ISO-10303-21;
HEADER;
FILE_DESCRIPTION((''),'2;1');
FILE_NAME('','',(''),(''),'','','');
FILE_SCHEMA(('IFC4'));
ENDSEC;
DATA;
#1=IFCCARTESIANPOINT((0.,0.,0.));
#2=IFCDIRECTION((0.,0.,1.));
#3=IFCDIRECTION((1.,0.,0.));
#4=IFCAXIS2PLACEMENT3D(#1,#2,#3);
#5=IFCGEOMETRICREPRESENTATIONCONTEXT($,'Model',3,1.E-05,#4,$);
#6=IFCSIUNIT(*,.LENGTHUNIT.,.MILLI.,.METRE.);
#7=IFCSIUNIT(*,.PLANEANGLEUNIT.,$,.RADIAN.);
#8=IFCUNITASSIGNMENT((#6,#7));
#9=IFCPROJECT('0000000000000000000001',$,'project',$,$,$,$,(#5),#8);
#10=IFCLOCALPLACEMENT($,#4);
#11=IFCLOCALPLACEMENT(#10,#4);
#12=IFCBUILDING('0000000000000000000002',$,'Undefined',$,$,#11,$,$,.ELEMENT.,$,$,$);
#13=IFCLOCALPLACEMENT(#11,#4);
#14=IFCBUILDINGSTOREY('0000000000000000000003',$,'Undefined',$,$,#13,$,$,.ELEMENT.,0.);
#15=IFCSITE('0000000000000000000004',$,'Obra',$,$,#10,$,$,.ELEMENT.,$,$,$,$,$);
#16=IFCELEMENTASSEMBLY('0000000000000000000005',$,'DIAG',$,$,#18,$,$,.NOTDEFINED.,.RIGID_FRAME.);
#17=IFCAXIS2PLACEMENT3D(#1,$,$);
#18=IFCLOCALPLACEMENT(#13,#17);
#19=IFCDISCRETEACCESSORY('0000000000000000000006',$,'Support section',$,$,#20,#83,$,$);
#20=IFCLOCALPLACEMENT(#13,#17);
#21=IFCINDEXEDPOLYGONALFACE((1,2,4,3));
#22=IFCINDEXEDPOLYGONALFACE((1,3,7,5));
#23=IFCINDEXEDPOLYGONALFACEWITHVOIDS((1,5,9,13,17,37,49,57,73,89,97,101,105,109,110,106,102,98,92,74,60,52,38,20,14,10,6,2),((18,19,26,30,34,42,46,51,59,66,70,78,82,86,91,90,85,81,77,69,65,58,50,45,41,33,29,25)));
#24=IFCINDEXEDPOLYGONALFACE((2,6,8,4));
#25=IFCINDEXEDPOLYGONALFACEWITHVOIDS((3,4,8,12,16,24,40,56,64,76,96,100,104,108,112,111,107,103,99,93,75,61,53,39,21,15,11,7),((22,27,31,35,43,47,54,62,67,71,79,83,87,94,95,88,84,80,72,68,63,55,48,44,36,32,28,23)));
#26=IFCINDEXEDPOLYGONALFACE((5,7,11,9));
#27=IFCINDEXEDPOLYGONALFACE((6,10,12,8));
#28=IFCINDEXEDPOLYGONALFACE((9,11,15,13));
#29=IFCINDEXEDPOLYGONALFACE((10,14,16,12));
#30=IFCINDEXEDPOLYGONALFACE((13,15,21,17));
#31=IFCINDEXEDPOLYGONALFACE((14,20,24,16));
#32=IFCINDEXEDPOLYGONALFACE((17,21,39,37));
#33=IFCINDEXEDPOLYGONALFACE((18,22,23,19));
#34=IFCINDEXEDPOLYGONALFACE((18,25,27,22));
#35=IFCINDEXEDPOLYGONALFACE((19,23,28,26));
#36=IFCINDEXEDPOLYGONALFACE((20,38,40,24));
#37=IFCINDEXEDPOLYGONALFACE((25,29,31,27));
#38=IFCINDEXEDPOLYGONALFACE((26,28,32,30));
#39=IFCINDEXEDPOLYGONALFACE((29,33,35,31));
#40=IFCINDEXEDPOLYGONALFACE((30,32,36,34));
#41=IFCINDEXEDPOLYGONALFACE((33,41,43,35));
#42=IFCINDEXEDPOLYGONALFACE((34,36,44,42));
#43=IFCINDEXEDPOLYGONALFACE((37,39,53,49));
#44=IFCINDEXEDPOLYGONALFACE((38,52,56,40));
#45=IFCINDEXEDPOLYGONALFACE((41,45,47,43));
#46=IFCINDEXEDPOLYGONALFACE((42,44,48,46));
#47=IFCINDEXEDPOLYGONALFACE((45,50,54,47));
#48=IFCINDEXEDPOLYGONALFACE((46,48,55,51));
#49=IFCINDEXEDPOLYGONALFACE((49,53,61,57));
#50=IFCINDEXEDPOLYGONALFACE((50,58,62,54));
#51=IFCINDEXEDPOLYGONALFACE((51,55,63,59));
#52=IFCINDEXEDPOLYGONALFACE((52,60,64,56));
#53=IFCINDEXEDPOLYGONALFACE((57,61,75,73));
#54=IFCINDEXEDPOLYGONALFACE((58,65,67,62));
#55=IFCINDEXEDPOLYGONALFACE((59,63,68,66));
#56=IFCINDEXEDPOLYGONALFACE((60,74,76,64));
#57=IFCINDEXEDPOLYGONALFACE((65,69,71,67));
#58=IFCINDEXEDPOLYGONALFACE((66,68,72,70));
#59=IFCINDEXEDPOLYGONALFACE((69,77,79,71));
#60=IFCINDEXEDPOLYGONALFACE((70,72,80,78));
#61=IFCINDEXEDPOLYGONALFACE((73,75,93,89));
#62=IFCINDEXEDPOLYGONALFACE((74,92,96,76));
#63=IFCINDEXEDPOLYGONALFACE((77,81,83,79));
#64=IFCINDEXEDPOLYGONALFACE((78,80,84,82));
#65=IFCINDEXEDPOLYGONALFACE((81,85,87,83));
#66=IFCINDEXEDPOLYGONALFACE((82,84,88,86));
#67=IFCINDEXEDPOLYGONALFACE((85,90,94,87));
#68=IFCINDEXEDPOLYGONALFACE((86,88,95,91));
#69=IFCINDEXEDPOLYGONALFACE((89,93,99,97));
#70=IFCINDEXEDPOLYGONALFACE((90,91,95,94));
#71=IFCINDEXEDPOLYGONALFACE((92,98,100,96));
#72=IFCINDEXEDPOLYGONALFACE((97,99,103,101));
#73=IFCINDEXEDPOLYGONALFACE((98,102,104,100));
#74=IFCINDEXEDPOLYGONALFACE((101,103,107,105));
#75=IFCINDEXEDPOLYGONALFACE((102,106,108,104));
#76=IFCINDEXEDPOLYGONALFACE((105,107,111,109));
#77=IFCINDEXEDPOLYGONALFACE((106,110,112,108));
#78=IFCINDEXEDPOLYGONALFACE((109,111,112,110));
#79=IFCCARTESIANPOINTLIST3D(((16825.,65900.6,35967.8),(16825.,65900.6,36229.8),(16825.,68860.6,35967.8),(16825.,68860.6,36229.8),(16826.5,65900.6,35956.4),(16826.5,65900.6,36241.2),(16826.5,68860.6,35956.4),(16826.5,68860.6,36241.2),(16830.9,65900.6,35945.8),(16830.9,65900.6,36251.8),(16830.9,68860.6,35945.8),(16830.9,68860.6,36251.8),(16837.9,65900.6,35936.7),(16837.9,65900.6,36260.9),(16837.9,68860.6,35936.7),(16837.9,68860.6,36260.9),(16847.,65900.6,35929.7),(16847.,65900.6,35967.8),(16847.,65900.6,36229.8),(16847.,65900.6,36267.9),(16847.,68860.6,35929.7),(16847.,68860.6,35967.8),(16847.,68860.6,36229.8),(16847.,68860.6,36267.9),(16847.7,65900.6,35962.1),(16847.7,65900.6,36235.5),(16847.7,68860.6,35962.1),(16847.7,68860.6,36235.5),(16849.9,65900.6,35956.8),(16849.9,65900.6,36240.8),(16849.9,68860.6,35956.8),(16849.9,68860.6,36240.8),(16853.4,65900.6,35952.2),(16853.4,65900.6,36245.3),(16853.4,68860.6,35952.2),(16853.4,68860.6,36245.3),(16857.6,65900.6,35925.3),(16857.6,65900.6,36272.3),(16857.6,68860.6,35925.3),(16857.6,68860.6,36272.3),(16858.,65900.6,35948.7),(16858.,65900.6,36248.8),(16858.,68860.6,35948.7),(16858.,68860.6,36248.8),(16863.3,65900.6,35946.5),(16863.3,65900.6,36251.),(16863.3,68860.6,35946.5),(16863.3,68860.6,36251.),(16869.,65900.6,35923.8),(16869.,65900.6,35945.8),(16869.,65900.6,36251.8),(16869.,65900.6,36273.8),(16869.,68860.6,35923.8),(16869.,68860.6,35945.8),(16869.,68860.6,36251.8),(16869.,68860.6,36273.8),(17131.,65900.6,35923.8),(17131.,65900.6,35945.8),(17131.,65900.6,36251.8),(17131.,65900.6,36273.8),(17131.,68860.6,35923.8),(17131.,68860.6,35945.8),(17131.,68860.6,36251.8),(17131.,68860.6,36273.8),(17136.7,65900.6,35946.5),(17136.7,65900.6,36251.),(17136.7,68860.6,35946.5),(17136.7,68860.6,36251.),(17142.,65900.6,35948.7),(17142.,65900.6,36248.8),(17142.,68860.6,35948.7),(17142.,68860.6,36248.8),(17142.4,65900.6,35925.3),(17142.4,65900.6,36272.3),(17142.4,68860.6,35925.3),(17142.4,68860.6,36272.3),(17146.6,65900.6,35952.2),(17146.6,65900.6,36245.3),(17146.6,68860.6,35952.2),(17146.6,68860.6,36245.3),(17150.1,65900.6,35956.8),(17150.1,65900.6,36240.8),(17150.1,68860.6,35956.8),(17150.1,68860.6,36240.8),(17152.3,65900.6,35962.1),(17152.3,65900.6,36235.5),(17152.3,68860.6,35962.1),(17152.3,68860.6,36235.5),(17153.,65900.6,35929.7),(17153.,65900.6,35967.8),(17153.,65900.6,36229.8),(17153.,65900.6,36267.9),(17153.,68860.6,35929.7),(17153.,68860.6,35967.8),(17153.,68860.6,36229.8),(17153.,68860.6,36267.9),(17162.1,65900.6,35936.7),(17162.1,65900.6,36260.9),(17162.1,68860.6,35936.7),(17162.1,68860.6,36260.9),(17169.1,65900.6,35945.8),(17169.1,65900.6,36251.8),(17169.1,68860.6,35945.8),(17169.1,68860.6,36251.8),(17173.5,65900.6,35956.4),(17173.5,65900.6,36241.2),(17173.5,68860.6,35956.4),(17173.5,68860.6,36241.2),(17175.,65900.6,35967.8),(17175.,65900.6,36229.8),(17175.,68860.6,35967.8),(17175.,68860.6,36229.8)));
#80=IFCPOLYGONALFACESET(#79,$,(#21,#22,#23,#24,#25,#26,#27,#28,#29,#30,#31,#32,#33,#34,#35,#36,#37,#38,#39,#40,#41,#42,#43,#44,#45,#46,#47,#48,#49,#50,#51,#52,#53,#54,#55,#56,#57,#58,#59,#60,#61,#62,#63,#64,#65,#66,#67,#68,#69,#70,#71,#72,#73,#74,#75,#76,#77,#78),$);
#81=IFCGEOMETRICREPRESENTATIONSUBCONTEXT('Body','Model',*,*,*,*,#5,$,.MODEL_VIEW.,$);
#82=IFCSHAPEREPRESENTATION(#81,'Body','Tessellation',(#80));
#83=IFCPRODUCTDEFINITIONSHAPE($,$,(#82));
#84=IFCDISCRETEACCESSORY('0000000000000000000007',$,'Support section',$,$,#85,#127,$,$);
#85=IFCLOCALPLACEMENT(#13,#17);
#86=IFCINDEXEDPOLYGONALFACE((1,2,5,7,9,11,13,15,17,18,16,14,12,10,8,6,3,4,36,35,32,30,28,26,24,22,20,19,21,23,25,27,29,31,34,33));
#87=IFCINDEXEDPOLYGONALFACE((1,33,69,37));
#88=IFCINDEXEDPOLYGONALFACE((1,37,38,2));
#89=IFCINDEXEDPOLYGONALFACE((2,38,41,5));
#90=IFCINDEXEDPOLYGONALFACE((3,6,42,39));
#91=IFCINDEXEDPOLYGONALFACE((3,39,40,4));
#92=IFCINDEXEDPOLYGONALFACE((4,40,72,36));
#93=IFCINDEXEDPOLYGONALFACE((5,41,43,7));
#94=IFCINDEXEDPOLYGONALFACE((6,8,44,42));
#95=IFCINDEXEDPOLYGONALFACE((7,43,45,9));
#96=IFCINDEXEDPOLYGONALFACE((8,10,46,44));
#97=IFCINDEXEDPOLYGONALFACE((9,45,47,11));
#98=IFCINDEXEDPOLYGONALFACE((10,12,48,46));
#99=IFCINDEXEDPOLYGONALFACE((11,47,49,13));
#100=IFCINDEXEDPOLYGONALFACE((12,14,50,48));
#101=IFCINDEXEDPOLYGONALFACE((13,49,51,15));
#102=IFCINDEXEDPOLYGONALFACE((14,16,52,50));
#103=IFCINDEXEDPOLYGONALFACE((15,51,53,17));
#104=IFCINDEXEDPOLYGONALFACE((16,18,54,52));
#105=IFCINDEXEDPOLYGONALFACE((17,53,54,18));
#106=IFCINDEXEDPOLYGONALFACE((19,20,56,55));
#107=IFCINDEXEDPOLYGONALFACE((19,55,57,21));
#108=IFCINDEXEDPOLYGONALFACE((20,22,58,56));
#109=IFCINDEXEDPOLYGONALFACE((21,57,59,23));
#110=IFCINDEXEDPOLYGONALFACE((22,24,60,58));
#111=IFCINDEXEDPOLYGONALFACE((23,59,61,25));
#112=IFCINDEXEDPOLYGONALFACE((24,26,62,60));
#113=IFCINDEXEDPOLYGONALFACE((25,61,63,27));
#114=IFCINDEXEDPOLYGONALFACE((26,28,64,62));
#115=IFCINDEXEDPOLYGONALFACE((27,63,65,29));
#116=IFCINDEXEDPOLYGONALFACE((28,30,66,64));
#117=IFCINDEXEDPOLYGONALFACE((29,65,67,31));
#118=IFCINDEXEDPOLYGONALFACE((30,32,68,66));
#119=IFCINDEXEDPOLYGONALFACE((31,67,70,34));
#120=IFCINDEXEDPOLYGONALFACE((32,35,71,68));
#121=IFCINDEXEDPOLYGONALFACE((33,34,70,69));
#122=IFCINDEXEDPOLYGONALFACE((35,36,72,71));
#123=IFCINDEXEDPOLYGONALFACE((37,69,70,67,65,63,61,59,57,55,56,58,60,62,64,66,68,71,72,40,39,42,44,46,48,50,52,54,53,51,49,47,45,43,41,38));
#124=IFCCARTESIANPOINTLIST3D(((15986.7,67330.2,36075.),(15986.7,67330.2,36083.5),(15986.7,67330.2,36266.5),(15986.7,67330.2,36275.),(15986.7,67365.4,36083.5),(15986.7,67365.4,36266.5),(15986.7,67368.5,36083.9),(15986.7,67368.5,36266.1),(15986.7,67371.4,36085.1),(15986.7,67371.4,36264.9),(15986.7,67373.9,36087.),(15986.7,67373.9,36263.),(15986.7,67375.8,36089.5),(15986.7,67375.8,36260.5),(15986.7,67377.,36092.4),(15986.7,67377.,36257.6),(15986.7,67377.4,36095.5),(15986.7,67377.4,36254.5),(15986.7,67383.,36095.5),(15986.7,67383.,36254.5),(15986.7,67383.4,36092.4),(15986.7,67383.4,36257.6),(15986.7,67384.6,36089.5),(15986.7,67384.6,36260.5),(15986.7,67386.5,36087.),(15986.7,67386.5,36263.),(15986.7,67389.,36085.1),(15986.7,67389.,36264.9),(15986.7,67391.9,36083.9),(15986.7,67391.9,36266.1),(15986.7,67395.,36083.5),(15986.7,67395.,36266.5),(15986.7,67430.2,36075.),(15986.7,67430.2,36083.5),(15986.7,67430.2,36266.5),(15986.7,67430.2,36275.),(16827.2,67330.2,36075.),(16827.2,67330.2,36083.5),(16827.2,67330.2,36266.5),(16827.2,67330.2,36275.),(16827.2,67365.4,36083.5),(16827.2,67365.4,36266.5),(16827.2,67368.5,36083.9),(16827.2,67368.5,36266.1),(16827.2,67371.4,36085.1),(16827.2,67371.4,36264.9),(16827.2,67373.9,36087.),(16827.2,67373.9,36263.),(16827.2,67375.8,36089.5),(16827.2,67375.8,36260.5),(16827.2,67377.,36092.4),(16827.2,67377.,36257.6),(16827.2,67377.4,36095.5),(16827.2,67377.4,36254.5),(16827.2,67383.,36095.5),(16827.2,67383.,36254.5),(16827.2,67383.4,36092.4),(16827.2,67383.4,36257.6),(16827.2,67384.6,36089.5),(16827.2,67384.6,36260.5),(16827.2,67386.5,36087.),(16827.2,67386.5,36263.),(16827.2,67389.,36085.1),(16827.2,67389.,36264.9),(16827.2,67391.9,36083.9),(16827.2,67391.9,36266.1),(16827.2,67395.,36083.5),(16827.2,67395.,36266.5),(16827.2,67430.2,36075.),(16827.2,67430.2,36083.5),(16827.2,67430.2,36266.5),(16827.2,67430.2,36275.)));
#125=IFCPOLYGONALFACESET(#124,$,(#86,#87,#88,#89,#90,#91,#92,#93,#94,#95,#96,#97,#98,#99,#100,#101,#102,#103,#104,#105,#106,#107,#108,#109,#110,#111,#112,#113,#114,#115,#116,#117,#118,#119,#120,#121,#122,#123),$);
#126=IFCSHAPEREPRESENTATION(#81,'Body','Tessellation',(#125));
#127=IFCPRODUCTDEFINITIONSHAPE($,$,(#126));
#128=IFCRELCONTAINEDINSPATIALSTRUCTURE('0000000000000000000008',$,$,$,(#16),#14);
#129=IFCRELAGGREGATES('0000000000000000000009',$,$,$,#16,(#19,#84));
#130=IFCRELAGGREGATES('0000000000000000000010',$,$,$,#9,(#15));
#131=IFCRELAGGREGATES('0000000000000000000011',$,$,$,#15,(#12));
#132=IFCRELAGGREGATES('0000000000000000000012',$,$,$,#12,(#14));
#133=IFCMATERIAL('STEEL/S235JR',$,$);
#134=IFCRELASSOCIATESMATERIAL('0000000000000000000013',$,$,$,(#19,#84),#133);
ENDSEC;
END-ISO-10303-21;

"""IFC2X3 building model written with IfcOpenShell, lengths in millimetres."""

from ifc_helpers import new_model, si_unit, frame, origin_with_axes, origin_2d_with_axis, place, context, subcontext, project, spatial, hollow_rectangle, i_section, extrude, clip, halfspace, material, element, aggregate, save


model = new_model("IFC2X3")

# Units and contexts
model_context = context("Model", 3, precision=1e-05, world=origin_with_axes())
body_context = subcontext(model_context, "Body", "Model", "MODEL_VIEW")
ifc_project = project(units=[si_unit("LENGTHUNIT", "METRE", prefix="MILLI"), si_unit("PLANEANGLEUNIT", "RADIAN")], contexts=[model_context])

# Site, building, storey
site_placement = place(None, origin_with_axes())
site = spatial("IfcSite", under=ifc_project, at=site_placement, Name="Obra", CompositionType="ELEMENT")
building_placement = place(site_placement, origin_with_axes())
building = spatial("IfcBuilding", under=site, at=building_placement, Name="Undefined", CompositionType="ELEMENT")
storey_placement = place(building_placement, origin_with_axes())
storey = spatial("IfcBuildingStorey", under=building, at=storey_placement, Name="Undefined", CompositionType="ELEMENT", Elevation=0.0)

# Element assembly
ifc_material_1 = material(Name="STEEL/S235JR")
assembly_1_placement = place(storey_placement, origin_with_axes())
assembly_1 = element("IfcElementAssembly", 1, at=assembly_1_placement, inside=storey, Name="DIAG", AssemblyPlace="NOTDEFINED", PredefinedType="RIGID_FRAME")

# Discrete accessories
discrete_accessory_1_placement = place(assembly_1_placement, frame((17000.0, 65880.6, 36098.8), z_axis=(0.0, 0.0, 1.0), x_axis=(0.0, 1.0, 0.0)))
discrete_accessory_1 = element("IfcDiscreteAccessory", 2, at=discrete_accessory_1_placement, material=ifc_material_1, Name="Support section", context=body_context, shape_type="Clipping", body=[
    clip(clip(extrude(hollow_rectangle(XDim=350.0, YDim=350.0, WallThickness=22.0, InnerFilletRadius=22.0, OuterFilletRadius=44.0, at=origin_2d_with_axis()), frame((2980.0, 0.0, 0.0), z_axis=(-1.0, 0.0, 0.0), x_axis=(0.0, -1.0, 0.0)), (0.0, 0.0, 1.0), 2960.1), halfspace(frame((2980.1, 0.0, -1000.0), z_axis=(-1.0, 0.0, -0.000097), x_axis=(0.0, 1.0, 0.0)), True)), halfspace(frame((20.0, 0.0, -175.0), z_axis=(1.0, 0.0, -0.000056), x_axis=(0.0, -1.0, 0.0)), True)),
])
discrete_accessory_2_placement = place(assembly_1_placement, frame((16827.2, 67380.2, 36175.0), z_axis=(0.0, 0.0, 1.0), x_axis=(-1.0, 0.0, 0.0)))
discrete_accessory_2 = element("IfcDiscreteAccessory", 3, at=discrete_accessory_2_placement, material=ifc_material_1, Name="Support section", context=body_context, shape_type="SweptSolid", body=[
    extrude(i_section(OverallWidth=100.0, OverallDepth=200.0, WebThickness=5.6, FlangeThickness=8.5, FilletRadius=12.0, at=origin_2d_with_axis()), frame((840.5, 0.0, 0.0), z_axis=(-1.0, 0.0, 0.0), x_axis=(0.0, -1.0, 0.0)), (0.0, 0.0, 1.0), 840.5),
])
aggregate(assembly_1, [discrete_accessory_1, discrete_accessory_2])

save(model, "model.ifc")
